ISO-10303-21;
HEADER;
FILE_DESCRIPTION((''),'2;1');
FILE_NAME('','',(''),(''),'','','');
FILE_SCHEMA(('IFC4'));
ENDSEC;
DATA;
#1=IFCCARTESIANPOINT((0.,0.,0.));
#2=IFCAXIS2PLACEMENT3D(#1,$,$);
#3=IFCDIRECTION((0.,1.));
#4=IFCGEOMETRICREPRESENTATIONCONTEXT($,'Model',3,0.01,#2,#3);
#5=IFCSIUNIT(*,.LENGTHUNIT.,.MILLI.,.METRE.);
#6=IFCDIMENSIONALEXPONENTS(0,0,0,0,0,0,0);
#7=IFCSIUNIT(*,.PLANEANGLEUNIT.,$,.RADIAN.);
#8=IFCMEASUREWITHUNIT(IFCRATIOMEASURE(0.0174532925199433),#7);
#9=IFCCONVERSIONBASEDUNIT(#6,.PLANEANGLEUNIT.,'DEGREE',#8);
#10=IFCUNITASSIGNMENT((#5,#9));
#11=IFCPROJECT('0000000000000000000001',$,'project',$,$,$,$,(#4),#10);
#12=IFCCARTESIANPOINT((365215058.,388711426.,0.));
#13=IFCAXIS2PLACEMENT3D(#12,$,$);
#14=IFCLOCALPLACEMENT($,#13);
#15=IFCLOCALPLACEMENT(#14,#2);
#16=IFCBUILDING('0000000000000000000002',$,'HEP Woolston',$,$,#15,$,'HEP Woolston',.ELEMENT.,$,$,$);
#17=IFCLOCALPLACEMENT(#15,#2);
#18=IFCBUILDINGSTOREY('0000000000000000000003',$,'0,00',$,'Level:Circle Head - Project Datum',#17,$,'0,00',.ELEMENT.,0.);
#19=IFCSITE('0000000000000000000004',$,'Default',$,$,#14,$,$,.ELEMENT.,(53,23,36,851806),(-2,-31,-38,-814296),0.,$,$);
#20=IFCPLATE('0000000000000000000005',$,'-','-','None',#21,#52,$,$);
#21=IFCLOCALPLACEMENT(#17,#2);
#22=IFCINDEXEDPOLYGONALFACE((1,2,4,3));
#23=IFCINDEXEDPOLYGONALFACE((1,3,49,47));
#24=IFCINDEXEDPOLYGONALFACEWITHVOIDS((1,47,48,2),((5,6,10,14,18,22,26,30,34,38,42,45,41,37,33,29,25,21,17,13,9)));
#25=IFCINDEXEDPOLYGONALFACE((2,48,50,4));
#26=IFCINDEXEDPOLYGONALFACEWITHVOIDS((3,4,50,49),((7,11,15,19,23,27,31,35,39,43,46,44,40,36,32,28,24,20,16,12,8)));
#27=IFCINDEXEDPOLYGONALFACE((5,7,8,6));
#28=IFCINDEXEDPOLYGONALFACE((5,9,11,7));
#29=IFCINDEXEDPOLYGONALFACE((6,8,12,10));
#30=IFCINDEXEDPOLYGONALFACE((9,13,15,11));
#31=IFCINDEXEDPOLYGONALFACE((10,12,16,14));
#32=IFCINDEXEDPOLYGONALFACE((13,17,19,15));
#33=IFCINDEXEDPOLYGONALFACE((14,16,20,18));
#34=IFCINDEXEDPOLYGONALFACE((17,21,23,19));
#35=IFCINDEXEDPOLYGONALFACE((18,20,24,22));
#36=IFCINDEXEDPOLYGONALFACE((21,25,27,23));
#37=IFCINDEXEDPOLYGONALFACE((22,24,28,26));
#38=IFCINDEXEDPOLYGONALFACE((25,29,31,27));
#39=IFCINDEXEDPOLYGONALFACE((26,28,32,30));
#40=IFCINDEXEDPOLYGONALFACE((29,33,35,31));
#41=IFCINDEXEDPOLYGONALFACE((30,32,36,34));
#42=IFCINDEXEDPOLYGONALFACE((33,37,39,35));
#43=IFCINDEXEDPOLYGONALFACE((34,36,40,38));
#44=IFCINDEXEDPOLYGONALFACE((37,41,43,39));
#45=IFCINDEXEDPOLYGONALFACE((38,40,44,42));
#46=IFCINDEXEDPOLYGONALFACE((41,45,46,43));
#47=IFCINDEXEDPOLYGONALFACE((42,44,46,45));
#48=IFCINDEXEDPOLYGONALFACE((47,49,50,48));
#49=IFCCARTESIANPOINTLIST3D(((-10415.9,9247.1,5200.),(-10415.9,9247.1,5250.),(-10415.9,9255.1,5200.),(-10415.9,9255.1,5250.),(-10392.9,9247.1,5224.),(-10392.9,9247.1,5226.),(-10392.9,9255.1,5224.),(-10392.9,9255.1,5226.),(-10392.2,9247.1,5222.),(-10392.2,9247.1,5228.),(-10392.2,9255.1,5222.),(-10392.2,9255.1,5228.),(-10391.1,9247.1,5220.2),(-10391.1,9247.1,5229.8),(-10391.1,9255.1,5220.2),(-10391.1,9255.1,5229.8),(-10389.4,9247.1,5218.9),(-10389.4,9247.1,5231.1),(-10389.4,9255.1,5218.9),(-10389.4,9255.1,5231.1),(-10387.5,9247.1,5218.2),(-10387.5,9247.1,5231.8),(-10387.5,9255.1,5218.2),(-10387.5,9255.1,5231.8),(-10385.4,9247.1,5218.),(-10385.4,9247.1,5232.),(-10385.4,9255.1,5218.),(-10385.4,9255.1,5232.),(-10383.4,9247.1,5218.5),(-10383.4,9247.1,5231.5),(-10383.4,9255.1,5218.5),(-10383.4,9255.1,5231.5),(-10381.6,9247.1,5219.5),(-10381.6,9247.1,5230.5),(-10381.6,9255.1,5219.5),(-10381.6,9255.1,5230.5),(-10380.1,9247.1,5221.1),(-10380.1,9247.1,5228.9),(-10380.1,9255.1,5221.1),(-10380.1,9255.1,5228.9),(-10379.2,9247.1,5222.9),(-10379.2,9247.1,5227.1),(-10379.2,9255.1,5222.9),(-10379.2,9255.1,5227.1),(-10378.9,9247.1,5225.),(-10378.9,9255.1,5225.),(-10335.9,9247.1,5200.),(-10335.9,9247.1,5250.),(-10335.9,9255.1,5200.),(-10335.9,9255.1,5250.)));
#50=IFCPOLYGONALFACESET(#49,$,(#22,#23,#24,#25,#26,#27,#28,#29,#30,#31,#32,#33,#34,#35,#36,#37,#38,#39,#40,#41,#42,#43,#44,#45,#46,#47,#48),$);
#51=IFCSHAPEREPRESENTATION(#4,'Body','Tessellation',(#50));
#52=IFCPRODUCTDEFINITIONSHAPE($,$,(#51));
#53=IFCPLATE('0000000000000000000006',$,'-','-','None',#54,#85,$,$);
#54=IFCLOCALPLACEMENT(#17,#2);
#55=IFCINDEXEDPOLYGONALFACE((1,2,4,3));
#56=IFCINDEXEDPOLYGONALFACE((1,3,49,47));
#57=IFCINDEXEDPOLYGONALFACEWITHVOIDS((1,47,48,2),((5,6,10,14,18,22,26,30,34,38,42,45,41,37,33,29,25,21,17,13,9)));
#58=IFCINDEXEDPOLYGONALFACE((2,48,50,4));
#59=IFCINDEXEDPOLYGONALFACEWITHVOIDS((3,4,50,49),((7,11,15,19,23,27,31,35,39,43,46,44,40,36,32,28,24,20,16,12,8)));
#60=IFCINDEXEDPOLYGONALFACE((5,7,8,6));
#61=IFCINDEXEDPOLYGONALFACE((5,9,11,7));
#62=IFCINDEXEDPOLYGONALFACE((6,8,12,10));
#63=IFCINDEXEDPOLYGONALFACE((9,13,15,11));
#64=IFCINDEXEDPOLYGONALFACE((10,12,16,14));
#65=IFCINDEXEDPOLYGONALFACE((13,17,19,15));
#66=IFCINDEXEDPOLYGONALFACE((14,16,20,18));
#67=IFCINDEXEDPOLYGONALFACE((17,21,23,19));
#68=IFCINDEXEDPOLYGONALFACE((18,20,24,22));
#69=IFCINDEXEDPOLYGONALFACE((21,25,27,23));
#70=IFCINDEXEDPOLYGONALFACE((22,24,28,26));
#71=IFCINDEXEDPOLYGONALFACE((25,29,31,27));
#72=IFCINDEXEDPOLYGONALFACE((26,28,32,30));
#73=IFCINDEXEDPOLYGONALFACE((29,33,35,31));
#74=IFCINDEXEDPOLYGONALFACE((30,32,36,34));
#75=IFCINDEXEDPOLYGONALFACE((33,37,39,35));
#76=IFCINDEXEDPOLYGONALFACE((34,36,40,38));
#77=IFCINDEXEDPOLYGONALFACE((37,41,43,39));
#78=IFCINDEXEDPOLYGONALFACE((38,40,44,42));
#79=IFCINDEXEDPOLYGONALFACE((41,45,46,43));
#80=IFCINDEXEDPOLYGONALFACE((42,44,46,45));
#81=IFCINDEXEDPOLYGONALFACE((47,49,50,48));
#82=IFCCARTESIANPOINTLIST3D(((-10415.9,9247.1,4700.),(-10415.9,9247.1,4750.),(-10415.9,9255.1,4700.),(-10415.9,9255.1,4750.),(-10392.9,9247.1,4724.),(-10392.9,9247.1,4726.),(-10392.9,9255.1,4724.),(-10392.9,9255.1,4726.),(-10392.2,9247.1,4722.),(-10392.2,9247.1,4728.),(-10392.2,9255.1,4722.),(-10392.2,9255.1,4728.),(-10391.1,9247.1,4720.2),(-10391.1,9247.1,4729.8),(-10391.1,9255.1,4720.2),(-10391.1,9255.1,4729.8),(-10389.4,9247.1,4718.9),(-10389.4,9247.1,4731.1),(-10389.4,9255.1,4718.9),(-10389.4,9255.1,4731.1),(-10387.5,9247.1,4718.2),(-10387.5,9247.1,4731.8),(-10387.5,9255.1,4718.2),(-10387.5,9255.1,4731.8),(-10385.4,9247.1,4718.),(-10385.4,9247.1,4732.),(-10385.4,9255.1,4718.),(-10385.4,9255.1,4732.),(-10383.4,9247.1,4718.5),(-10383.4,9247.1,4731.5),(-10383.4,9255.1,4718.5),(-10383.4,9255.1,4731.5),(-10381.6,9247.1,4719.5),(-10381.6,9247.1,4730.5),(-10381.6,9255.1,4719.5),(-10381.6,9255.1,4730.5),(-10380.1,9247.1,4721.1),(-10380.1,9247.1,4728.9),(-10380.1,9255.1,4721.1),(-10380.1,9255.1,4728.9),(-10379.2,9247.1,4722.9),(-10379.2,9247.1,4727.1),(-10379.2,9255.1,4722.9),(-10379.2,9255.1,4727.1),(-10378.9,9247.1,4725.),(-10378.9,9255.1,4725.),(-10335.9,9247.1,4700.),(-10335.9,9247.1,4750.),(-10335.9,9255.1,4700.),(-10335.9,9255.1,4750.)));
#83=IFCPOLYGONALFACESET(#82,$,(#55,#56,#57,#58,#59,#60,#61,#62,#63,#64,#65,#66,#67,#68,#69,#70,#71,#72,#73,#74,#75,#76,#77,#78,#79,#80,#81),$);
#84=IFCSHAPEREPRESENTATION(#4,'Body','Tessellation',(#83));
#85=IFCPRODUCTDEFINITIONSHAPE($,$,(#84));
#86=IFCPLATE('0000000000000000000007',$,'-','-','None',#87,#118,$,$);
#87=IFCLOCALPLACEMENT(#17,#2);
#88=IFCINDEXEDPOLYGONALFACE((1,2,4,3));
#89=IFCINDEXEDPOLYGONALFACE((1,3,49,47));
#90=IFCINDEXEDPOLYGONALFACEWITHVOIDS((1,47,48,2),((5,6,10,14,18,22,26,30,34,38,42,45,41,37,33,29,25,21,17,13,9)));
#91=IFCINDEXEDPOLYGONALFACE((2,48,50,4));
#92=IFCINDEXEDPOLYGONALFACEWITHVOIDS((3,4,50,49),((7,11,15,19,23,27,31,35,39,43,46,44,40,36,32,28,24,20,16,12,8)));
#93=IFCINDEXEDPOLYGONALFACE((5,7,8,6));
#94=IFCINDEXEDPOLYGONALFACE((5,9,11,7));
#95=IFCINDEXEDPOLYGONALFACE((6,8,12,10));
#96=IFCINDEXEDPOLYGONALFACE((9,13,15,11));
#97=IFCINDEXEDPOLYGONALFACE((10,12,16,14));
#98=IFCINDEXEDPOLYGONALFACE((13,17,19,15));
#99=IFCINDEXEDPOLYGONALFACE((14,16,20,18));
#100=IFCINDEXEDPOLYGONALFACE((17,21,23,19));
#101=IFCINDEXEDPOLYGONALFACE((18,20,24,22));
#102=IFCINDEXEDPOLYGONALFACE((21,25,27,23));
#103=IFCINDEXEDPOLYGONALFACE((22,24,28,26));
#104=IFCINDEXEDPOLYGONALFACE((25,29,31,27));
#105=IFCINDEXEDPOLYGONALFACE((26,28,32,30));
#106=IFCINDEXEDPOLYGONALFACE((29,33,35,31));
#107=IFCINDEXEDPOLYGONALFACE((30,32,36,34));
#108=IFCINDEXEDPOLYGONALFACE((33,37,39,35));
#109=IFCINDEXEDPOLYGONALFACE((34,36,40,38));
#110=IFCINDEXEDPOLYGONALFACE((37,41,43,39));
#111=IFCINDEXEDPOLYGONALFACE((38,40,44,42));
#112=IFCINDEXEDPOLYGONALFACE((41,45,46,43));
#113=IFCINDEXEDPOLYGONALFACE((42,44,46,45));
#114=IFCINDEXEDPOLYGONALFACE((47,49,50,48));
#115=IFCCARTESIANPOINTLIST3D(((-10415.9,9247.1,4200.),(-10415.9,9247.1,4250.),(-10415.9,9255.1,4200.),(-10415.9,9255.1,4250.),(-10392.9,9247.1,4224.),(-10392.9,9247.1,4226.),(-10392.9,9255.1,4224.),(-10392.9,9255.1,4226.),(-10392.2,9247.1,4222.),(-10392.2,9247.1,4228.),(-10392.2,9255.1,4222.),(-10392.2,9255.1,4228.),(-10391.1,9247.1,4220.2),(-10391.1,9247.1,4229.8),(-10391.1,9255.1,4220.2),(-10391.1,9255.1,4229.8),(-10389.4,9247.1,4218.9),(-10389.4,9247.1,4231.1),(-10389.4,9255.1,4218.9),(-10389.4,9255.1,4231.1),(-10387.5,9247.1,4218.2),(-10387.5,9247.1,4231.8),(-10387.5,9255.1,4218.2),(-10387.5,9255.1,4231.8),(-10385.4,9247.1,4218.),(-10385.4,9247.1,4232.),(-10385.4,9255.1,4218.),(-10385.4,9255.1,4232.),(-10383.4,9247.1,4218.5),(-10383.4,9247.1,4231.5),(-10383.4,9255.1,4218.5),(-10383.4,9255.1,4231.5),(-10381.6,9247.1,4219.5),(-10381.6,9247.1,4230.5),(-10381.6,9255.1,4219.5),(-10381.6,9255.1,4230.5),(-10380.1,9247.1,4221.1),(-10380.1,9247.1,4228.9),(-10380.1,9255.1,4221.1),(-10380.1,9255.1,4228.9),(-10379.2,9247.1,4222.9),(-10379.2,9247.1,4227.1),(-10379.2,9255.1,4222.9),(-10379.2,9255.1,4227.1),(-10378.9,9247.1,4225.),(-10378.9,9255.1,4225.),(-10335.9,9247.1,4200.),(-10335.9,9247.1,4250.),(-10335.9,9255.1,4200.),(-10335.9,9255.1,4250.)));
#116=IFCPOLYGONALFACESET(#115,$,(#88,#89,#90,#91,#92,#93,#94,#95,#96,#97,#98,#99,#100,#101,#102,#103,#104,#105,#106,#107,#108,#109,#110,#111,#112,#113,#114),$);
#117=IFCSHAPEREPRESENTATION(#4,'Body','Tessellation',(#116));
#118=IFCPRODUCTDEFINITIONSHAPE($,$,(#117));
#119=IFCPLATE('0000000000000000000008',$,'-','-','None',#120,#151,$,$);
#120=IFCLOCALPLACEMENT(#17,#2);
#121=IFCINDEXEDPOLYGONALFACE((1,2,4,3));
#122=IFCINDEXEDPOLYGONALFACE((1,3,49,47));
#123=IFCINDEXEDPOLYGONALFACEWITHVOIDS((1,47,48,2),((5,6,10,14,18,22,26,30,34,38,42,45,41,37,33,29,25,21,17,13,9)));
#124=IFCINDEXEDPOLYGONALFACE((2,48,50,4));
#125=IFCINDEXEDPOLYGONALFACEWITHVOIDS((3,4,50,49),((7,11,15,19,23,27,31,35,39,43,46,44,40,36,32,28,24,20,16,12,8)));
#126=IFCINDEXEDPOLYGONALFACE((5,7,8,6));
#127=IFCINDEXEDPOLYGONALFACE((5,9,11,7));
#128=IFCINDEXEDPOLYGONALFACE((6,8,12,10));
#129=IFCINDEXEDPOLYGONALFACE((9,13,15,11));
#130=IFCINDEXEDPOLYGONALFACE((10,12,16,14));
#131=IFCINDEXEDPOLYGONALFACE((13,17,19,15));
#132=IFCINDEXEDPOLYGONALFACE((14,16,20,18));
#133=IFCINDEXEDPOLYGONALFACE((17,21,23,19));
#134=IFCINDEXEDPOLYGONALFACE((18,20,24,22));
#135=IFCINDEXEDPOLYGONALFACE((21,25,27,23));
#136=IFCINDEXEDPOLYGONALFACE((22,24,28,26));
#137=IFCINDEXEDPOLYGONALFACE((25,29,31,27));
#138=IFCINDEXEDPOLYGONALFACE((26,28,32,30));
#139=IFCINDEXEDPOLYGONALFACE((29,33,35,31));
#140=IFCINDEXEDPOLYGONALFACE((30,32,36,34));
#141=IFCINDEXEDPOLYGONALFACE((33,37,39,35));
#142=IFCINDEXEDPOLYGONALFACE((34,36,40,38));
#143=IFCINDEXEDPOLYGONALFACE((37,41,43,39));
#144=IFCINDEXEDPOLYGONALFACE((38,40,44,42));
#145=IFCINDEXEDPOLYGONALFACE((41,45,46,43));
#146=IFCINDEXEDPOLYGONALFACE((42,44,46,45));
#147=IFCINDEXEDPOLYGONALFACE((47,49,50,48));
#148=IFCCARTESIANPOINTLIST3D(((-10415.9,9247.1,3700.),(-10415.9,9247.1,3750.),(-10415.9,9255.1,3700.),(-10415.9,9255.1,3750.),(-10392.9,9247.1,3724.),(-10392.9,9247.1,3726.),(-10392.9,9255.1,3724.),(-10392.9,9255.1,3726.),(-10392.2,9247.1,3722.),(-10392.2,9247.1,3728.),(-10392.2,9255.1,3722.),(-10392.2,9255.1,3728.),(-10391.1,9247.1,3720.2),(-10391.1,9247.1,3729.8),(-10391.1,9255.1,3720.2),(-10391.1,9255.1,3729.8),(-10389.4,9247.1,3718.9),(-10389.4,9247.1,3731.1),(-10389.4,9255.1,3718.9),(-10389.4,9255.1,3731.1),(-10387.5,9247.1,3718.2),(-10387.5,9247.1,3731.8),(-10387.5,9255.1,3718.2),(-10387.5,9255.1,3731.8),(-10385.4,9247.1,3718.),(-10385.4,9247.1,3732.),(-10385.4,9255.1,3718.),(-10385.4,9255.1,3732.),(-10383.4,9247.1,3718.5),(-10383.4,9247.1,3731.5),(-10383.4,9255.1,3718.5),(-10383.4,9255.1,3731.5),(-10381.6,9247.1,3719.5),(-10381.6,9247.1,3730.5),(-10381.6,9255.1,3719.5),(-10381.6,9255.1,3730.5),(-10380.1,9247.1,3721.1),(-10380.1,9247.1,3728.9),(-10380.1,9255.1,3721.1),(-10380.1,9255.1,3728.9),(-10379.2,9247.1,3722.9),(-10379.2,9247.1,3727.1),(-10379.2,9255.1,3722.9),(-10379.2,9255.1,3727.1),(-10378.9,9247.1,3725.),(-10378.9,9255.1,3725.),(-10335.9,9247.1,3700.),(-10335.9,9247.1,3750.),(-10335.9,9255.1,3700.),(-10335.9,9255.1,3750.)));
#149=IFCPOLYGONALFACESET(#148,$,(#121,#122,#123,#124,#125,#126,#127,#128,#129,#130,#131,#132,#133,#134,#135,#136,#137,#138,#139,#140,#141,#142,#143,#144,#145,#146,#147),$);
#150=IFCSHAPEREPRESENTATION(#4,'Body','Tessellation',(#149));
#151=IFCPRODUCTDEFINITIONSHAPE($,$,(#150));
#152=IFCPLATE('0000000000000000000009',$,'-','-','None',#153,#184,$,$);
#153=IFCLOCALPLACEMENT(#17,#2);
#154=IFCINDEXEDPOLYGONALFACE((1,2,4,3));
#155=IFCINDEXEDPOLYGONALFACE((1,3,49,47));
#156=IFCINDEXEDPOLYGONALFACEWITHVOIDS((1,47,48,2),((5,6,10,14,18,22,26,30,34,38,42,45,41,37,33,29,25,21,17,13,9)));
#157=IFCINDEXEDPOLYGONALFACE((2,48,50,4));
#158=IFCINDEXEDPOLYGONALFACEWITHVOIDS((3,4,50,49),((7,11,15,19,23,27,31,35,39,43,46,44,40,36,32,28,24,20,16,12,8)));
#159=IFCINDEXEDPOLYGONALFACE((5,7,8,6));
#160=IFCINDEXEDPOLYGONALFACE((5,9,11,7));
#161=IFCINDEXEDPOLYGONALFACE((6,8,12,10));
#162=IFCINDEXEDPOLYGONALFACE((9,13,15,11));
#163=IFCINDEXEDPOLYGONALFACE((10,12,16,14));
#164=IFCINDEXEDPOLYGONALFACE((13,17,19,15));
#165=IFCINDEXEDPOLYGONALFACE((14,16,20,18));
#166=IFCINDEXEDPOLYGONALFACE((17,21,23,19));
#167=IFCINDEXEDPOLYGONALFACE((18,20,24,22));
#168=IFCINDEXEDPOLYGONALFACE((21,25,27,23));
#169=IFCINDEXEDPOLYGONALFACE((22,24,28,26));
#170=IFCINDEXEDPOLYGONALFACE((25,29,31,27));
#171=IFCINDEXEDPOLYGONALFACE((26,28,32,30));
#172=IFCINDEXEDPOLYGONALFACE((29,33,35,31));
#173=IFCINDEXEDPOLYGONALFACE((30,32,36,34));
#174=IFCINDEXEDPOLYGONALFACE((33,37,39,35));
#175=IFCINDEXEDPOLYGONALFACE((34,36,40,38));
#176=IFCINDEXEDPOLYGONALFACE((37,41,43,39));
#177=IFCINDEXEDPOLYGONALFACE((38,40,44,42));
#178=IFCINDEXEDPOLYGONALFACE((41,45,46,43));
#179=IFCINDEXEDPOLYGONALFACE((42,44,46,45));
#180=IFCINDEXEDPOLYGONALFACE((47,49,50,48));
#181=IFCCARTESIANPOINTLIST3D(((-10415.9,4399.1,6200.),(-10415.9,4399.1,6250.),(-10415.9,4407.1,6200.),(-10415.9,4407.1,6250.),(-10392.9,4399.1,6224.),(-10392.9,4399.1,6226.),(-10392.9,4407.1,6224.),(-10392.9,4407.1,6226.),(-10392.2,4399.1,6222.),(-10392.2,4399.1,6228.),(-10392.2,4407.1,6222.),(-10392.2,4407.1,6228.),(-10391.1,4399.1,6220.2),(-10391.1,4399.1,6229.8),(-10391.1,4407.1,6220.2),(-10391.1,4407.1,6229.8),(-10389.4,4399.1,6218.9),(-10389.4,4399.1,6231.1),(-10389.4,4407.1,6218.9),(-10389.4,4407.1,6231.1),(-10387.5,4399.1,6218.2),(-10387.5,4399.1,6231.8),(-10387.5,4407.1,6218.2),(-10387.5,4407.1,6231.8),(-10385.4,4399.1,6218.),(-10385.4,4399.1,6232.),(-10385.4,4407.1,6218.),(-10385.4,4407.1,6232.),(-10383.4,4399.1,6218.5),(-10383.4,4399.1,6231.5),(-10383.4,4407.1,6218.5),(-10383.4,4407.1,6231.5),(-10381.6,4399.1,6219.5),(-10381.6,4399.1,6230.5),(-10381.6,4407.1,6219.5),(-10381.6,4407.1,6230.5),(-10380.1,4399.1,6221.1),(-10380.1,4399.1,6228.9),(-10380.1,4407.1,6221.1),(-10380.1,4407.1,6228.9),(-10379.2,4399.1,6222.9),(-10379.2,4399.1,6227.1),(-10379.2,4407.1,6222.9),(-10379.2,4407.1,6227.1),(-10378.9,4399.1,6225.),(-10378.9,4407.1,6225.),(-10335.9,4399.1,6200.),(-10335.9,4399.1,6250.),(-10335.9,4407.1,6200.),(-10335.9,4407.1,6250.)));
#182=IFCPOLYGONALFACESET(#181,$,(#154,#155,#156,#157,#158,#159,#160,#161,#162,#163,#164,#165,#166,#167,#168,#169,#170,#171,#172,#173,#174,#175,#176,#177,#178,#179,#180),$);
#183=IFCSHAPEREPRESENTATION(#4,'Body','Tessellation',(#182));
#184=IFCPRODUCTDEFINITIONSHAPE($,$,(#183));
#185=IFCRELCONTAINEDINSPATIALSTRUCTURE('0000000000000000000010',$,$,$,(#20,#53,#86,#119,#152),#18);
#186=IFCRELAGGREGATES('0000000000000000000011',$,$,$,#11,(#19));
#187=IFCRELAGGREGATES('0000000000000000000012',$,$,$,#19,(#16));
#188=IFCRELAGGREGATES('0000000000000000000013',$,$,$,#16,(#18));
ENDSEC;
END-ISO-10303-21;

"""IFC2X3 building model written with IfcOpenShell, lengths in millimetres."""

from ifc_helpers import new_model, entity, si_unit, converted_unit, direction, frame, frame_2d, origin, origin_with_axes, origin_2d_with_axis, place, context, project, spatial, polyline, circle, outline, extrude, element, save


model = new_model("IFC2X3")

# Units and contexts
model_context = context("Model", 3, precision=0.01, world=origin(), true_north=direction((0.0, 1.0)))
ifc_project = project(units=[si_unit("LENGTHUNIT", "METRE", prefix="MILLI"), converted_unit("PLANEANGLEUNIT", "DEGREE", entity("IfcRatioMeasure", 0.0174532925199433), si_unit("PLANEANGLEUNIT", "RADIAN"), dimensions=[0, 0, 0, 0, 0, 0, 0])], contexts=[model_context])

# Site, building, storey
site_placement = place(None, frame((365215058.0, 388711426.0, 0.0)))
site = spatial("IfcSite", under=ifc_project, at=site_placement, Name="Default", CompositionType="ELEMENT", RefLatitude=(53, 23, 36, 851806), RefLongitude=(-2, -31, -38, -814296), RefElevation=0.0)
building_placement = place(site_placement, origin())
building = spatial("IfcBuilding", under=site, at=building_placement, Name="HEP Woolston", LongName="HEP Woolston", CompositionType="ELEMENT")
storey_placement = place(building_placement, origin())
storey = spatial("IfcBuildingStorey", under=building, at=storey_placement, Name="0,00", ObjectType="Level:Circle Head - Project Datum", LongName="0,00", CompositionType="ELEMENT", Elevation=0.0)

# Plates, openings
plate_1_placement = place(storey_placement, frame((-10335.9, 9247.1, 5250.0), z_axis=(0.0, 1.0, 0.0), x_axis=(-1.0, 0.0, 0.0)))
plate_1 = element("IfcPlate", 1, at=plate_1_placement, inside=storey, Name="-", Description="-", ObjectType="None", context=model_context, shape_type="SweptSolid", body=[
    extrude(outline(polyline([(0.0, 0.0), (0.0, -50.0), (80.0, -50.0), (80.0, 0.0), (0.0, 0.0)])), origin_with_axes(), (0.0, 0.0, 1.0), 8.0),
])
opening_1_placement = place(plate_1_placement, frame((50.0, -25.0, 8.5), z_axis=(0.0, 0.0, -1.0), x_axis=(-1.0, 0.0, 0.0)))
element("IfcOpeningElement", 2, at=opening_1_placement, cuts=plate_1, ObjectType="Opening", context=model_context, shape_type="SweptSolid", body=[
    extrude(circle(Radius=7.0, at=origin_2d_with_axis()), origin(), (0.0, 0.0, 1.0), 9.0),
])
plate_2_placement = place(storey_placement, frame((-10335.9, 9247.1, 4750.0), z_axis=(0.0, 1.0, 0.0), x_axis=(-1.0, 0.0, 0.0)))
plate_2 = element("IfcPlate", 3, at=plate_2_placement, inside=storey, Name="-", Description="-", ObjectType="None", context=model_context, shape_type="SweptSolid", body=[
    extrude(outline(polyline([(0.0, 0.0), (0.0, -50.0), (80.0, -50.0), (80.0, 0.0), (0.0, 0.0)])), origin_with_axes(), (0.0, 0.0, 1.0), 8.0),
])
opening_2_placement = place(plate_2_placement, frame((50.0, -25.0, 8.5), z_axis=(0.0, 0.0, -1.0), x_axis=(-1.0, 0.0, 0.0)))
element("IfcOpeningElement", 4, at=opening_2_placement, cuts=plate_2, ObjectType="Opening", context=model_context, shape_type="SweptSolid", body=[
    extrude(circle(Radius=7.0, at=origin_2d_with_axis()), origin(), (0.0, 0.0, 1.0), 9.0),
])
plate_3_placement = place(storey_placement, frame((-10335.9, 9247.1, 4250.0), z_axis=(0.0, 1.0, 0.0), x_axis=(-1.0, 0.0, 0.0)))
plate_3 = element("IfcPlate", 5, at=plate_3_placement, inside=storey, Name="-", Description="-", ObjectType="None", context=model_context, shape_type="SweptSolid", body=[
    extrude(outline(polyline([(0.0, 0.0), (0.0, -50.0), (80.0, -50.0), (80.0, 0.0), (0.0, 0.0)])), origin_with_axes(), (0.0, 0.0, 1.0), 8.0),
])
opening_3_placement = place(plate_3_placement, frame((50.0, -25.0, 8.5), z_axis=(0.0, 0.0, -1.0), x_axis=(-1.0, 0.0, 0.0)))
element("IfcOpeningElement", 6, at=opening_3_placement, cuts=plate_3, ObjectType="Opening", context=model_context, shape_type="SweptSolid", body=[
    extrude(circle(Radius=7.0, at=origin_2d_with_axis()), origin(), (0.0, 0.0, 1.0), 9.0),
])
plate_4_placement = place(storey_placement, frame((-10335.9, 9247.1, 3750.0), z_axis=(0.0, 1.0, 0.0), x_axis=(-1.0, 0.0, 0.0)))
plate_4 = element("IfcPlate", 7, at=plate_4_placement, inside=storey, Name="-", Description="-", ObjectType="None", context=model_context, shape_type="SweptSolid", body=[
    extrude(outline(polyline([(0.0, 0.0), (0.0, -50.0), (80.0, -50.0), (80.0, 0.0), (0.0, 0.0)])), origin_with_axes(), (0.0, 0.0, 1.0), 8.0),
])
opening_4_placement = place(plate_4_placement, frame((50.0, -25.0, 8.5), z_axis=(0.0, 0.0, -1.0), x_axis=(-1.0, 0.0, 0.0)))
element("IfcOpeningElement", 8, at=opening_4_placement, cuts=plate_4, ObjectType="Opening", context=model_context, shape_type="SweptSolid", body=[
    extrude(circle(Radius=7.0, at=origin_2d_with_axis()), origin(), (0.0, 0.0, 1.0), 9.0),
])
plate_5_placement = place(storey_placement, frame((-10335.9, 4407.1, 6250.0), z_axis=(0.0, 1.0, 0.0), x_axis=(-1.0, 0.0, 0.0)))
plate_5 = element("IfcPlate", 9, at=plate_5_placement, inside=storey, Name="-", Description="-", ObjectType="None", context=model_context, shape_type="SweptSolid", body=[
    extrude(outline(polyline([(0.0, 0.0), (0.0, -50.0), (80.0, -50.0), (80.0, 0.0), (0.0, 0.0)])), origin_with_axes(), (0.0, 0.0, -1.0), 8.0),
])
opening_5_placement = place(plate_5_placement, frame((57.0, -25.0, -8.5), z_axis=(0.0, 0.0, -1.0), x_axis=(-1.0, 0.0, 0.0)))
element("IfcOpeningElement", 10, at=opening_5_placement, cuts=plate_5, ObjectType="Opening", context=model_context, shape_type="SweptSolid", body=[
    extrude(circle(Radius=7.0, at=frame_2d((7.0, 0.0), x_axis=(1.0, 0.0))), origin(), (0.0, 0.0, -1.0), 9.0),
])

save(model, "model.ifc")
